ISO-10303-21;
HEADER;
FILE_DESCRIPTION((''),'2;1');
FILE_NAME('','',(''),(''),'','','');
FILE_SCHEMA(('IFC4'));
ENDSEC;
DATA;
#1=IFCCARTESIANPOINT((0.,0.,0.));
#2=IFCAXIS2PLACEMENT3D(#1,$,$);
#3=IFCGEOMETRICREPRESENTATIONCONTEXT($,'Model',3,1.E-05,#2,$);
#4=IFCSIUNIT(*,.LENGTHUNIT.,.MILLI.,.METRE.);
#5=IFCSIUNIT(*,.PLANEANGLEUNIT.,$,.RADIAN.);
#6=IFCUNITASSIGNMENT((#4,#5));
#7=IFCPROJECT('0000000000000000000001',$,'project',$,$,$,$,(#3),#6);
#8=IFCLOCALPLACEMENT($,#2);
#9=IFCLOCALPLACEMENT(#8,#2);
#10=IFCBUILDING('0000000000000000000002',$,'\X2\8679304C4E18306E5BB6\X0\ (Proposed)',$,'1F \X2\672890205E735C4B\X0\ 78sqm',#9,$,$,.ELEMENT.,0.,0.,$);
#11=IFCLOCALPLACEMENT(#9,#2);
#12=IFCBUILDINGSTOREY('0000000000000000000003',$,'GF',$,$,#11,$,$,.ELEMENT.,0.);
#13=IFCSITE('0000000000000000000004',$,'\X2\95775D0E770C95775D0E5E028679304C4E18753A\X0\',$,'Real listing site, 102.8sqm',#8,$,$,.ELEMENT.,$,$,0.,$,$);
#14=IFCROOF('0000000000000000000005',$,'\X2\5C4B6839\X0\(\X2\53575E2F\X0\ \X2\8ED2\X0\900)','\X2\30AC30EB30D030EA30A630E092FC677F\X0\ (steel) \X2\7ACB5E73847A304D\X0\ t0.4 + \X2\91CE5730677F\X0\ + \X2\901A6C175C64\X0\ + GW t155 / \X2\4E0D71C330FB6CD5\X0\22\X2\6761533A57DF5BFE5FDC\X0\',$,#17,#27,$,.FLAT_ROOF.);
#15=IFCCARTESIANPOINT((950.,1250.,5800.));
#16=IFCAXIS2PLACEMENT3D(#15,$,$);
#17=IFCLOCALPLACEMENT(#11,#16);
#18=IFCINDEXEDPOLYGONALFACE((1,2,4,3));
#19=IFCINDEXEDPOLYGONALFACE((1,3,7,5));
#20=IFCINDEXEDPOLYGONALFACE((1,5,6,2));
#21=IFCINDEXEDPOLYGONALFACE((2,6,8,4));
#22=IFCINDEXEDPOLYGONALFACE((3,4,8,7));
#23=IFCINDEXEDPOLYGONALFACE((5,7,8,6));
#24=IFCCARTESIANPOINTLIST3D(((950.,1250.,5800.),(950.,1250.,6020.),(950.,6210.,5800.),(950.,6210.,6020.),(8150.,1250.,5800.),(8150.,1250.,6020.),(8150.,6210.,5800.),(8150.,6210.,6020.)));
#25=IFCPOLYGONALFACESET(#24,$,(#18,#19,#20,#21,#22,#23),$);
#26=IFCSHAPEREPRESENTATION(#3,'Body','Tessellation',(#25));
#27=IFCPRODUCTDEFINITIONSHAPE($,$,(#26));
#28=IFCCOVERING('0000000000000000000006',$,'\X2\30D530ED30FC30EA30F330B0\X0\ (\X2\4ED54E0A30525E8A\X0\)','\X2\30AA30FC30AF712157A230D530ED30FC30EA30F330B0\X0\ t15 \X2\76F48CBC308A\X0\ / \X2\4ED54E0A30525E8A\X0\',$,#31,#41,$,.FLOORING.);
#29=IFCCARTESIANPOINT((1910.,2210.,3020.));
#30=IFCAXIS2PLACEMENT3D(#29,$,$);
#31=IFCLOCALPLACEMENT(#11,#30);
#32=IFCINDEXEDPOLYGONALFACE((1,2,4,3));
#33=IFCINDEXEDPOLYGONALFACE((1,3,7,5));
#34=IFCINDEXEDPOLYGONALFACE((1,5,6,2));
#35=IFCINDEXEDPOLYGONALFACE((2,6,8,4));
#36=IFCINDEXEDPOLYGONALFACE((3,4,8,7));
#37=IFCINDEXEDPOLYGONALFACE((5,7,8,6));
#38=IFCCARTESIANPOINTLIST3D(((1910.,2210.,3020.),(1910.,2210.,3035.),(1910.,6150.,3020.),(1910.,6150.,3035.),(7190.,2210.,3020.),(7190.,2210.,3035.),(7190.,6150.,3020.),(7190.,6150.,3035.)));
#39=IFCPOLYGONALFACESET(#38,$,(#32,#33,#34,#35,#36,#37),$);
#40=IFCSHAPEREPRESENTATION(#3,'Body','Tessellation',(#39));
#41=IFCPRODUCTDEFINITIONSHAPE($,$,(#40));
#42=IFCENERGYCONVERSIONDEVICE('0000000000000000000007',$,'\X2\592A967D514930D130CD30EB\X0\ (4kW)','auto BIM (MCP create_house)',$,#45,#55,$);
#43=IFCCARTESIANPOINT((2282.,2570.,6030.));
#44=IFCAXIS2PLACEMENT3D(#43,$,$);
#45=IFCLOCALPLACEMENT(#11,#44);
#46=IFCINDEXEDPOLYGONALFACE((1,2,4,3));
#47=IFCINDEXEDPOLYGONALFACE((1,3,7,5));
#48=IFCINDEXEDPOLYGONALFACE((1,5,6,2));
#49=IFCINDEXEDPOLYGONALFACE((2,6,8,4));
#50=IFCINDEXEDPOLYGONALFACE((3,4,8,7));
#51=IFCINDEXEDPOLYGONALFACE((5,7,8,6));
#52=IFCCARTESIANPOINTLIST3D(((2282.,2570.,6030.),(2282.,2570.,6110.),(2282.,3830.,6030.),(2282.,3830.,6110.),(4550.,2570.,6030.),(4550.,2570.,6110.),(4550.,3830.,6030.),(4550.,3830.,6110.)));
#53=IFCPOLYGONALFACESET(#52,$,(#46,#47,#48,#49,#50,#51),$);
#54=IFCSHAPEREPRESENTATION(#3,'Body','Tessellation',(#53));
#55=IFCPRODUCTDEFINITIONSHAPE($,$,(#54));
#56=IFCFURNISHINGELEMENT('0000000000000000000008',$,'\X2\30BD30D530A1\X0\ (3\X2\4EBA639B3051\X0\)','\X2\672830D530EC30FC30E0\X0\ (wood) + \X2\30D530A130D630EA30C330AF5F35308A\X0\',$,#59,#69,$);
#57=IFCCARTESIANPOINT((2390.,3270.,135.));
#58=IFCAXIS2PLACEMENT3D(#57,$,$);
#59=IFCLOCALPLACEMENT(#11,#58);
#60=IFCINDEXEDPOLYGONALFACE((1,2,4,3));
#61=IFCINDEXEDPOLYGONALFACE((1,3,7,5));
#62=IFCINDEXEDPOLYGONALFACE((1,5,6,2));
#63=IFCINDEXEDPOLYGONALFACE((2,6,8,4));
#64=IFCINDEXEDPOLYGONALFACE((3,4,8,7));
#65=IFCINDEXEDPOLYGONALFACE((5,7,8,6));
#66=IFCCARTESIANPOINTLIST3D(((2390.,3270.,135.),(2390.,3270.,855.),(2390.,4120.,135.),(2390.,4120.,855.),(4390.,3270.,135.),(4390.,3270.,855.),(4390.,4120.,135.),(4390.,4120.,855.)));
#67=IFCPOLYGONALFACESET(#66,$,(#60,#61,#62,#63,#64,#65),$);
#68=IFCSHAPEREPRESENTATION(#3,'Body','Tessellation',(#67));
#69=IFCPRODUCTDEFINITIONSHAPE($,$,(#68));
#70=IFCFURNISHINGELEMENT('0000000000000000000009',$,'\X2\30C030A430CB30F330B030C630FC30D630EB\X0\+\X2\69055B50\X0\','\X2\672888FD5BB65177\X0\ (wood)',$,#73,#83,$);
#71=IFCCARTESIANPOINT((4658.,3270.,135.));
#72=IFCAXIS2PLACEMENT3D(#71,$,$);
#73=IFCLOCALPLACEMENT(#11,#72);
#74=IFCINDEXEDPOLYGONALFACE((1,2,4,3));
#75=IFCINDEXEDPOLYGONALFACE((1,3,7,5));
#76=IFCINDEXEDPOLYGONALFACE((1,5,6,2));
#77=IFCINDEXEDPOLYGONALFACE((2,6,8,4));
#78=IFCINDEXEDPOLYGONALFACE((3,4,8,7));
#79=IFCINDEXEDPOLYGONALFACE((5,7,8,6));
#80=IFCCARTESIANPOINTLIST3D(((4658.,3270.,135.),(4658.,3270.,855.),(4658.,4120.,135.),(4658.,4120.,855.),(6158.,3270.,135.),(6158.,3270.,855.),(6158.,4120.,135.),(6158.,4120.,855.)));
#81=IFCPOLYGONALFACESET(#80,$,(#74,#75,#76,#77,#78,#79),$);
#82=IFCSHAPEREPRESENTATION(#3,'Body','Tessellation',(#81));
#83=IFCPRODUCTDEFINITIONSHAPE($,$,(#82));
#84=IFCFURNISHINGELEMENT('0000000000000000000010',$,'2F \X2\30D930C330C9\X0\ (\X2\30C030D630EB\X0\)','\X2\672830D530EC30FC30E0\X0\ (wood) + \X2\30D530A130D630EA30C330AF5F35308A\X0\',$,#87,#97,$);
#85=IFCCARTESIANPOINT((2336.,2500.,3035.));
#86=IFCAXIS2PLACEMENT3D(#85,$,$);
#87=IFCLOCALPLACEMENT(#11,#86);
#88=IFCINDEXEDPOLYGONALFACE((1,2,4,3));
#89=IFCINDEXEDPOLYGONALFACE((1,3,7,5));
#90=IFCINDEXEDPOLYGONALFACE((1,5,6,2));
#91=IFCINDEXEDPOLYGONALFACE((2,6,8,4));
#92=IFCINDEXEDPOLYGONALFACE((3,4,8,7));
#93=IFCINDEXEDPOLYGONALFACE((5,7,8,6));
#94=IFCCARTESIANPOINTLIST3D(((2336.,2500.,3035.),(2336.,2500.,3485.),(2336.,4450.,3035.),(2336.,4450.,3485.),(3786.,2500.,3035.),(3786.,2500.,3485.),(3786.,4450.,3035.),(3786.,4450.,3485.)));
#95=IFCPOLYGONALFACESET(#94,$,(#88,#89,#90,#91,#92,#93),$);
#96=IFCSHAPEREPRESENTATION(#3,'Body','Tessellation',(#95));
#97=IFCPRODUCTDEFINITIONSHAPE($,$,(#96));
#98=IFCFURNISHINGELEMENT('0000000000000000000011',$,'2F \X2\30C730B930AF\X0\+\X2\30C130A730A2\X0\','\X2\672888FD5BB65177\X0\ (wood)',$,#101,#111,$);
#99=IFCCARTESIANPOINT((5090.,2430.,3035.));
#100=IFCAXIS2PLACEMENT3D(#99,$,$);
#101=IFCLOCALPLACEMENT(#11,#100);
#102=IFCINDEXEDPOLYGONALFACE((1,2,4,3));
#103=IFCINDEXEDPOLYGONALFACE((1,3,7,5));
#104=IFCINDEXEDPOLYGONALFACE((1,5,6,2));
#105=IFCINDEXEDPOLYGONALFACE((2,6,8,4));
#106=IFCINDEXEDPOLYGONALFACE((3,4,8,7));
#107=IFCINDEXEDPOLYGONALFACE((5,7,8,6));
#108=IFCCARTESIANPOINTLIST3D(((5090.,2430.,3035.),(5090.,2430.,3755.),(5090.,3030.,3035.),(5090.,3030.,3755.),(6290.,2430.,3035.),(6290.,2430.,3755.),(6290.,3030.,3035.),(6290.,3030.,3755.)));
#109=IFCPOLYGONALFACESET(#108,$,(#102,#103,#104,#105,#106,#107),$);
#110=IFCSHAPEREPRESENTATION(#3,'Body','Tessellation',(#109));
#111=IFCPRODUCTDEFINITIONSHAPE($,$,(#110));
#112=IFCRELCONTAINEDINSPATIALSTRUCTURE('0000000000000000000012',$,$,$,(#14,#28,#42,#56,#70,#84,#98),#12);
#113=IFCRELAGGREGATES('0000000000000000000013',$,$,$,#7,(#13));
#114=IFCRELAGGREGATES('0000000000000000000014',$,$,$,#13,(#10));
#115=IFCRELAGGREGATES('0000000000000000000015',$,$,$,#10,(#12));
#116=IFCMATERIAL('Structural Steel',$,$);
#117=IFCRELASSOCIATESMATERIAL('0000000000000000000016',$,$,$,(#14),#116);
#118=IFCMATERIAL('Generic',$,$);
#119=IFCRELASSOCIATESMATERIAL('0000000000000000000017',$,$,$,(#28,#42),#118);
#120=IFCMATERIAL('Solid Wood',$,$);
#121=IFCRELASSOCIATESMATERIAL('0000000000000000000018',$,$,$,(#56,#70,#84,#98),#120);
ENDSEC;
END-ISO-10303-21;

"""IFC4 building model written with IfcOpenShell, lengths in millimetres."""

from ifc_helpers import new_model, si_unit, frame, frame_2d, origin, place, context, project, spatial, rectangle, extrude, material, element, save


model = new_model("IFC4")

# Units and contexts
model_context = context("Model", 3, precision=1e-05, world=origin())
ifc_project = project(units=[si_unit("LENGTHUNIT", "METRE", prefix="MILLI"), si_unit("PLANEANGLEUNIT", "RADIAN")], contexts=[model_context])

# Site, building, storey
site_placement = place(None, origin())
site = spatial("IfcSite", under=ifc_project, at=site_placement, Name="長崎県長崎市虹が丘町", ObjectType="Real listing site, 102.8sqm", CompositionType="ELEMENT", RefElevation=0.0)
building_placement = place(site_placement, origin())
building = spatial("IfcBuilding", under=site, at=building_placement, Name="虹が丘の家 (Proposed)", ObjectType="1F 木造平屋 78sqm", CompositionType="ELEMENT", ElevationOfRefHeight=0.0, ElevationOfTerrain=0.0)
storey_placement = place(building_placement, origin())
storey = spatial("IfcBuildingStorey", under=building, at=storey_placement, Name="GF", CompositionType="ELEMENT", Elevation=0.0)

# Shared definitions
ifc_material_1 = material(Name="Solid Wood")

# Shared definitions
ifc_material_2 = material(Name="Generic")

# Roof
ifc_material_3 = material(Name="Structural Steel")
for number, where, name in (
    (1, (950.0, 1250.0, 5800.0), "屋根(南帯 軒900)"),
):
    element("IfcRoof", number, at=place(storey_placement, frame(where)), inside=storey, material=ifc_material_3, Name=name, Description="ガルバリウム鋼板 (steel) 立平葺き t0.4 + 野地板 + 通気層 + GW t155 / 不燃・法22条区域対応", PredefinedType="FLAT_ROOF", context=model_context, shape_type="SweptSolid", body=[
        extrude(rectangle(XDim=7200.0, YDim=4960.0, at=frame_2d((3600.0, 2480.0))), frame((950.0, 1250.0, 5800.0)), (0.0, 0.0, 1.0), 220.0),
    ])

# Covering
covering_placement = place(storey_placement, frame((1910.0, 2210.0, 3020.0)))
element("IfcCovering", 2, at=covering_placement, inside=storey, material=ifc_material_2, Name="フローリング (仕上げ床)", Description="オーク無垢フローリング t15 直貼り / 仕上げ床", PredefinedType="FLOORING", context=model_context, shape_type="SweptSolid", body=[
    extrude(rectangle(XDim=5280.0, YDim=3940.0, at=frame_2d((2640.0, 1970.0))), frame((1910.0, 2210.0, 3020.0)), (0.0, 0.0, 1.0), 15.0),
])

# Energy conversion device
energy_conversion_device_placement = place(storey_placement, frame((2282.0, 2570.0, 6030.0)))
element("IfcEnergyConversionDevice", 3, at=energy_conversion_device_placement, inside=storey, material=ifc_material_2, Name="太陽光パネル (4kW)", Description="auto BIM (MCP create_house)", context=model_context, shape_type="SweptSolid", body=[
    extrude(rectangle(XDim=2268.0, YDim=1260.0, at=frame_2d((1134.0, 630.0))), frame((2282.0, 2570.0, 6030.0)), (0.0, 0.0, 1.0), 80.0),
])

# Furnishing elements
furnishing_1_placement = place(storey_placement, frame((2390.0, 3270.0, 135.0)))
element("IfcFurnishingElement", 4, at=furnishing_1_placement, inside=storey, material=ifc_material_1, Name="ソファ (3人掛け)", Description="木フレーム (wood) + ファブリック張り", context=model_context, shape_type="SweptSolid", body=[
    extrude(rectangle(XDim=2000.0, YDim=850.0, at=frame_2d((1000.0, 425.0))), frame((2390.0, 3270.0, 135.0)), (0.0, 0.0, 1.0), 720.0),
])
furnishing_2_placement = place(storey_placement, frame((4658.0, 3270.0, 135.0)))
element("IfcFurnishingElement", 5, at=furnishing_2_placement, inside=storey, material=ifc_material_1, Name="ダイニングテーブル+椅子", Description="木製家具 (wood)", context=model_context, shape_type="SweptSolid", body=[
    extrude(rectangle(XDim=1500.0, YDim=850.0, at=frame_2d((750.0, 425.0))), frame((4658.0, 3270.0, 135.0)), (0.0, 0.0, 1.0), 720.0),
])
furnishing_3_placement = place(storey_placement, frame((2336.0, 2500.0, 3035.0)))
element("IfcFurnishingElement", 6, at=furnishing_3_placement, inside=storey, material=ifc_material_1, Name="2F ベッド (ダブル)", Description="木フレーム (wood) + ファブリック張り", context=model_context, shape_type="SweptSolid", body=[
    extrude(rectangle(XDim=1450.0, YDim=1950.0, at=frame_2d((725.0, 975.0))), frame((2336.0, 2500.0, 3035.0)), (0.0, 0.0, 1.0), 450.0),
])
furnishing_4_placement = place(storey_placement, frame((5090.0, 2430.0, 3035.0)))
element("IfcFurnishingElement", 7, at=furnishing_4_placement, inside=storey, material=ifc_material_1, Name="2F デスク+チェア", Description="木製家具 (wood)", context=model_context, shape_type="SweptSolid", body=[
    extrude(rectangle(XDim=1200.0, YDim=600.0, at=frame_2d((600.0, 300.0))), frame((5090.0, 2430.0, 3035.0)), (0.0, 0.0, 1.0), 720.0),
])

save(model, "model.ifc")
